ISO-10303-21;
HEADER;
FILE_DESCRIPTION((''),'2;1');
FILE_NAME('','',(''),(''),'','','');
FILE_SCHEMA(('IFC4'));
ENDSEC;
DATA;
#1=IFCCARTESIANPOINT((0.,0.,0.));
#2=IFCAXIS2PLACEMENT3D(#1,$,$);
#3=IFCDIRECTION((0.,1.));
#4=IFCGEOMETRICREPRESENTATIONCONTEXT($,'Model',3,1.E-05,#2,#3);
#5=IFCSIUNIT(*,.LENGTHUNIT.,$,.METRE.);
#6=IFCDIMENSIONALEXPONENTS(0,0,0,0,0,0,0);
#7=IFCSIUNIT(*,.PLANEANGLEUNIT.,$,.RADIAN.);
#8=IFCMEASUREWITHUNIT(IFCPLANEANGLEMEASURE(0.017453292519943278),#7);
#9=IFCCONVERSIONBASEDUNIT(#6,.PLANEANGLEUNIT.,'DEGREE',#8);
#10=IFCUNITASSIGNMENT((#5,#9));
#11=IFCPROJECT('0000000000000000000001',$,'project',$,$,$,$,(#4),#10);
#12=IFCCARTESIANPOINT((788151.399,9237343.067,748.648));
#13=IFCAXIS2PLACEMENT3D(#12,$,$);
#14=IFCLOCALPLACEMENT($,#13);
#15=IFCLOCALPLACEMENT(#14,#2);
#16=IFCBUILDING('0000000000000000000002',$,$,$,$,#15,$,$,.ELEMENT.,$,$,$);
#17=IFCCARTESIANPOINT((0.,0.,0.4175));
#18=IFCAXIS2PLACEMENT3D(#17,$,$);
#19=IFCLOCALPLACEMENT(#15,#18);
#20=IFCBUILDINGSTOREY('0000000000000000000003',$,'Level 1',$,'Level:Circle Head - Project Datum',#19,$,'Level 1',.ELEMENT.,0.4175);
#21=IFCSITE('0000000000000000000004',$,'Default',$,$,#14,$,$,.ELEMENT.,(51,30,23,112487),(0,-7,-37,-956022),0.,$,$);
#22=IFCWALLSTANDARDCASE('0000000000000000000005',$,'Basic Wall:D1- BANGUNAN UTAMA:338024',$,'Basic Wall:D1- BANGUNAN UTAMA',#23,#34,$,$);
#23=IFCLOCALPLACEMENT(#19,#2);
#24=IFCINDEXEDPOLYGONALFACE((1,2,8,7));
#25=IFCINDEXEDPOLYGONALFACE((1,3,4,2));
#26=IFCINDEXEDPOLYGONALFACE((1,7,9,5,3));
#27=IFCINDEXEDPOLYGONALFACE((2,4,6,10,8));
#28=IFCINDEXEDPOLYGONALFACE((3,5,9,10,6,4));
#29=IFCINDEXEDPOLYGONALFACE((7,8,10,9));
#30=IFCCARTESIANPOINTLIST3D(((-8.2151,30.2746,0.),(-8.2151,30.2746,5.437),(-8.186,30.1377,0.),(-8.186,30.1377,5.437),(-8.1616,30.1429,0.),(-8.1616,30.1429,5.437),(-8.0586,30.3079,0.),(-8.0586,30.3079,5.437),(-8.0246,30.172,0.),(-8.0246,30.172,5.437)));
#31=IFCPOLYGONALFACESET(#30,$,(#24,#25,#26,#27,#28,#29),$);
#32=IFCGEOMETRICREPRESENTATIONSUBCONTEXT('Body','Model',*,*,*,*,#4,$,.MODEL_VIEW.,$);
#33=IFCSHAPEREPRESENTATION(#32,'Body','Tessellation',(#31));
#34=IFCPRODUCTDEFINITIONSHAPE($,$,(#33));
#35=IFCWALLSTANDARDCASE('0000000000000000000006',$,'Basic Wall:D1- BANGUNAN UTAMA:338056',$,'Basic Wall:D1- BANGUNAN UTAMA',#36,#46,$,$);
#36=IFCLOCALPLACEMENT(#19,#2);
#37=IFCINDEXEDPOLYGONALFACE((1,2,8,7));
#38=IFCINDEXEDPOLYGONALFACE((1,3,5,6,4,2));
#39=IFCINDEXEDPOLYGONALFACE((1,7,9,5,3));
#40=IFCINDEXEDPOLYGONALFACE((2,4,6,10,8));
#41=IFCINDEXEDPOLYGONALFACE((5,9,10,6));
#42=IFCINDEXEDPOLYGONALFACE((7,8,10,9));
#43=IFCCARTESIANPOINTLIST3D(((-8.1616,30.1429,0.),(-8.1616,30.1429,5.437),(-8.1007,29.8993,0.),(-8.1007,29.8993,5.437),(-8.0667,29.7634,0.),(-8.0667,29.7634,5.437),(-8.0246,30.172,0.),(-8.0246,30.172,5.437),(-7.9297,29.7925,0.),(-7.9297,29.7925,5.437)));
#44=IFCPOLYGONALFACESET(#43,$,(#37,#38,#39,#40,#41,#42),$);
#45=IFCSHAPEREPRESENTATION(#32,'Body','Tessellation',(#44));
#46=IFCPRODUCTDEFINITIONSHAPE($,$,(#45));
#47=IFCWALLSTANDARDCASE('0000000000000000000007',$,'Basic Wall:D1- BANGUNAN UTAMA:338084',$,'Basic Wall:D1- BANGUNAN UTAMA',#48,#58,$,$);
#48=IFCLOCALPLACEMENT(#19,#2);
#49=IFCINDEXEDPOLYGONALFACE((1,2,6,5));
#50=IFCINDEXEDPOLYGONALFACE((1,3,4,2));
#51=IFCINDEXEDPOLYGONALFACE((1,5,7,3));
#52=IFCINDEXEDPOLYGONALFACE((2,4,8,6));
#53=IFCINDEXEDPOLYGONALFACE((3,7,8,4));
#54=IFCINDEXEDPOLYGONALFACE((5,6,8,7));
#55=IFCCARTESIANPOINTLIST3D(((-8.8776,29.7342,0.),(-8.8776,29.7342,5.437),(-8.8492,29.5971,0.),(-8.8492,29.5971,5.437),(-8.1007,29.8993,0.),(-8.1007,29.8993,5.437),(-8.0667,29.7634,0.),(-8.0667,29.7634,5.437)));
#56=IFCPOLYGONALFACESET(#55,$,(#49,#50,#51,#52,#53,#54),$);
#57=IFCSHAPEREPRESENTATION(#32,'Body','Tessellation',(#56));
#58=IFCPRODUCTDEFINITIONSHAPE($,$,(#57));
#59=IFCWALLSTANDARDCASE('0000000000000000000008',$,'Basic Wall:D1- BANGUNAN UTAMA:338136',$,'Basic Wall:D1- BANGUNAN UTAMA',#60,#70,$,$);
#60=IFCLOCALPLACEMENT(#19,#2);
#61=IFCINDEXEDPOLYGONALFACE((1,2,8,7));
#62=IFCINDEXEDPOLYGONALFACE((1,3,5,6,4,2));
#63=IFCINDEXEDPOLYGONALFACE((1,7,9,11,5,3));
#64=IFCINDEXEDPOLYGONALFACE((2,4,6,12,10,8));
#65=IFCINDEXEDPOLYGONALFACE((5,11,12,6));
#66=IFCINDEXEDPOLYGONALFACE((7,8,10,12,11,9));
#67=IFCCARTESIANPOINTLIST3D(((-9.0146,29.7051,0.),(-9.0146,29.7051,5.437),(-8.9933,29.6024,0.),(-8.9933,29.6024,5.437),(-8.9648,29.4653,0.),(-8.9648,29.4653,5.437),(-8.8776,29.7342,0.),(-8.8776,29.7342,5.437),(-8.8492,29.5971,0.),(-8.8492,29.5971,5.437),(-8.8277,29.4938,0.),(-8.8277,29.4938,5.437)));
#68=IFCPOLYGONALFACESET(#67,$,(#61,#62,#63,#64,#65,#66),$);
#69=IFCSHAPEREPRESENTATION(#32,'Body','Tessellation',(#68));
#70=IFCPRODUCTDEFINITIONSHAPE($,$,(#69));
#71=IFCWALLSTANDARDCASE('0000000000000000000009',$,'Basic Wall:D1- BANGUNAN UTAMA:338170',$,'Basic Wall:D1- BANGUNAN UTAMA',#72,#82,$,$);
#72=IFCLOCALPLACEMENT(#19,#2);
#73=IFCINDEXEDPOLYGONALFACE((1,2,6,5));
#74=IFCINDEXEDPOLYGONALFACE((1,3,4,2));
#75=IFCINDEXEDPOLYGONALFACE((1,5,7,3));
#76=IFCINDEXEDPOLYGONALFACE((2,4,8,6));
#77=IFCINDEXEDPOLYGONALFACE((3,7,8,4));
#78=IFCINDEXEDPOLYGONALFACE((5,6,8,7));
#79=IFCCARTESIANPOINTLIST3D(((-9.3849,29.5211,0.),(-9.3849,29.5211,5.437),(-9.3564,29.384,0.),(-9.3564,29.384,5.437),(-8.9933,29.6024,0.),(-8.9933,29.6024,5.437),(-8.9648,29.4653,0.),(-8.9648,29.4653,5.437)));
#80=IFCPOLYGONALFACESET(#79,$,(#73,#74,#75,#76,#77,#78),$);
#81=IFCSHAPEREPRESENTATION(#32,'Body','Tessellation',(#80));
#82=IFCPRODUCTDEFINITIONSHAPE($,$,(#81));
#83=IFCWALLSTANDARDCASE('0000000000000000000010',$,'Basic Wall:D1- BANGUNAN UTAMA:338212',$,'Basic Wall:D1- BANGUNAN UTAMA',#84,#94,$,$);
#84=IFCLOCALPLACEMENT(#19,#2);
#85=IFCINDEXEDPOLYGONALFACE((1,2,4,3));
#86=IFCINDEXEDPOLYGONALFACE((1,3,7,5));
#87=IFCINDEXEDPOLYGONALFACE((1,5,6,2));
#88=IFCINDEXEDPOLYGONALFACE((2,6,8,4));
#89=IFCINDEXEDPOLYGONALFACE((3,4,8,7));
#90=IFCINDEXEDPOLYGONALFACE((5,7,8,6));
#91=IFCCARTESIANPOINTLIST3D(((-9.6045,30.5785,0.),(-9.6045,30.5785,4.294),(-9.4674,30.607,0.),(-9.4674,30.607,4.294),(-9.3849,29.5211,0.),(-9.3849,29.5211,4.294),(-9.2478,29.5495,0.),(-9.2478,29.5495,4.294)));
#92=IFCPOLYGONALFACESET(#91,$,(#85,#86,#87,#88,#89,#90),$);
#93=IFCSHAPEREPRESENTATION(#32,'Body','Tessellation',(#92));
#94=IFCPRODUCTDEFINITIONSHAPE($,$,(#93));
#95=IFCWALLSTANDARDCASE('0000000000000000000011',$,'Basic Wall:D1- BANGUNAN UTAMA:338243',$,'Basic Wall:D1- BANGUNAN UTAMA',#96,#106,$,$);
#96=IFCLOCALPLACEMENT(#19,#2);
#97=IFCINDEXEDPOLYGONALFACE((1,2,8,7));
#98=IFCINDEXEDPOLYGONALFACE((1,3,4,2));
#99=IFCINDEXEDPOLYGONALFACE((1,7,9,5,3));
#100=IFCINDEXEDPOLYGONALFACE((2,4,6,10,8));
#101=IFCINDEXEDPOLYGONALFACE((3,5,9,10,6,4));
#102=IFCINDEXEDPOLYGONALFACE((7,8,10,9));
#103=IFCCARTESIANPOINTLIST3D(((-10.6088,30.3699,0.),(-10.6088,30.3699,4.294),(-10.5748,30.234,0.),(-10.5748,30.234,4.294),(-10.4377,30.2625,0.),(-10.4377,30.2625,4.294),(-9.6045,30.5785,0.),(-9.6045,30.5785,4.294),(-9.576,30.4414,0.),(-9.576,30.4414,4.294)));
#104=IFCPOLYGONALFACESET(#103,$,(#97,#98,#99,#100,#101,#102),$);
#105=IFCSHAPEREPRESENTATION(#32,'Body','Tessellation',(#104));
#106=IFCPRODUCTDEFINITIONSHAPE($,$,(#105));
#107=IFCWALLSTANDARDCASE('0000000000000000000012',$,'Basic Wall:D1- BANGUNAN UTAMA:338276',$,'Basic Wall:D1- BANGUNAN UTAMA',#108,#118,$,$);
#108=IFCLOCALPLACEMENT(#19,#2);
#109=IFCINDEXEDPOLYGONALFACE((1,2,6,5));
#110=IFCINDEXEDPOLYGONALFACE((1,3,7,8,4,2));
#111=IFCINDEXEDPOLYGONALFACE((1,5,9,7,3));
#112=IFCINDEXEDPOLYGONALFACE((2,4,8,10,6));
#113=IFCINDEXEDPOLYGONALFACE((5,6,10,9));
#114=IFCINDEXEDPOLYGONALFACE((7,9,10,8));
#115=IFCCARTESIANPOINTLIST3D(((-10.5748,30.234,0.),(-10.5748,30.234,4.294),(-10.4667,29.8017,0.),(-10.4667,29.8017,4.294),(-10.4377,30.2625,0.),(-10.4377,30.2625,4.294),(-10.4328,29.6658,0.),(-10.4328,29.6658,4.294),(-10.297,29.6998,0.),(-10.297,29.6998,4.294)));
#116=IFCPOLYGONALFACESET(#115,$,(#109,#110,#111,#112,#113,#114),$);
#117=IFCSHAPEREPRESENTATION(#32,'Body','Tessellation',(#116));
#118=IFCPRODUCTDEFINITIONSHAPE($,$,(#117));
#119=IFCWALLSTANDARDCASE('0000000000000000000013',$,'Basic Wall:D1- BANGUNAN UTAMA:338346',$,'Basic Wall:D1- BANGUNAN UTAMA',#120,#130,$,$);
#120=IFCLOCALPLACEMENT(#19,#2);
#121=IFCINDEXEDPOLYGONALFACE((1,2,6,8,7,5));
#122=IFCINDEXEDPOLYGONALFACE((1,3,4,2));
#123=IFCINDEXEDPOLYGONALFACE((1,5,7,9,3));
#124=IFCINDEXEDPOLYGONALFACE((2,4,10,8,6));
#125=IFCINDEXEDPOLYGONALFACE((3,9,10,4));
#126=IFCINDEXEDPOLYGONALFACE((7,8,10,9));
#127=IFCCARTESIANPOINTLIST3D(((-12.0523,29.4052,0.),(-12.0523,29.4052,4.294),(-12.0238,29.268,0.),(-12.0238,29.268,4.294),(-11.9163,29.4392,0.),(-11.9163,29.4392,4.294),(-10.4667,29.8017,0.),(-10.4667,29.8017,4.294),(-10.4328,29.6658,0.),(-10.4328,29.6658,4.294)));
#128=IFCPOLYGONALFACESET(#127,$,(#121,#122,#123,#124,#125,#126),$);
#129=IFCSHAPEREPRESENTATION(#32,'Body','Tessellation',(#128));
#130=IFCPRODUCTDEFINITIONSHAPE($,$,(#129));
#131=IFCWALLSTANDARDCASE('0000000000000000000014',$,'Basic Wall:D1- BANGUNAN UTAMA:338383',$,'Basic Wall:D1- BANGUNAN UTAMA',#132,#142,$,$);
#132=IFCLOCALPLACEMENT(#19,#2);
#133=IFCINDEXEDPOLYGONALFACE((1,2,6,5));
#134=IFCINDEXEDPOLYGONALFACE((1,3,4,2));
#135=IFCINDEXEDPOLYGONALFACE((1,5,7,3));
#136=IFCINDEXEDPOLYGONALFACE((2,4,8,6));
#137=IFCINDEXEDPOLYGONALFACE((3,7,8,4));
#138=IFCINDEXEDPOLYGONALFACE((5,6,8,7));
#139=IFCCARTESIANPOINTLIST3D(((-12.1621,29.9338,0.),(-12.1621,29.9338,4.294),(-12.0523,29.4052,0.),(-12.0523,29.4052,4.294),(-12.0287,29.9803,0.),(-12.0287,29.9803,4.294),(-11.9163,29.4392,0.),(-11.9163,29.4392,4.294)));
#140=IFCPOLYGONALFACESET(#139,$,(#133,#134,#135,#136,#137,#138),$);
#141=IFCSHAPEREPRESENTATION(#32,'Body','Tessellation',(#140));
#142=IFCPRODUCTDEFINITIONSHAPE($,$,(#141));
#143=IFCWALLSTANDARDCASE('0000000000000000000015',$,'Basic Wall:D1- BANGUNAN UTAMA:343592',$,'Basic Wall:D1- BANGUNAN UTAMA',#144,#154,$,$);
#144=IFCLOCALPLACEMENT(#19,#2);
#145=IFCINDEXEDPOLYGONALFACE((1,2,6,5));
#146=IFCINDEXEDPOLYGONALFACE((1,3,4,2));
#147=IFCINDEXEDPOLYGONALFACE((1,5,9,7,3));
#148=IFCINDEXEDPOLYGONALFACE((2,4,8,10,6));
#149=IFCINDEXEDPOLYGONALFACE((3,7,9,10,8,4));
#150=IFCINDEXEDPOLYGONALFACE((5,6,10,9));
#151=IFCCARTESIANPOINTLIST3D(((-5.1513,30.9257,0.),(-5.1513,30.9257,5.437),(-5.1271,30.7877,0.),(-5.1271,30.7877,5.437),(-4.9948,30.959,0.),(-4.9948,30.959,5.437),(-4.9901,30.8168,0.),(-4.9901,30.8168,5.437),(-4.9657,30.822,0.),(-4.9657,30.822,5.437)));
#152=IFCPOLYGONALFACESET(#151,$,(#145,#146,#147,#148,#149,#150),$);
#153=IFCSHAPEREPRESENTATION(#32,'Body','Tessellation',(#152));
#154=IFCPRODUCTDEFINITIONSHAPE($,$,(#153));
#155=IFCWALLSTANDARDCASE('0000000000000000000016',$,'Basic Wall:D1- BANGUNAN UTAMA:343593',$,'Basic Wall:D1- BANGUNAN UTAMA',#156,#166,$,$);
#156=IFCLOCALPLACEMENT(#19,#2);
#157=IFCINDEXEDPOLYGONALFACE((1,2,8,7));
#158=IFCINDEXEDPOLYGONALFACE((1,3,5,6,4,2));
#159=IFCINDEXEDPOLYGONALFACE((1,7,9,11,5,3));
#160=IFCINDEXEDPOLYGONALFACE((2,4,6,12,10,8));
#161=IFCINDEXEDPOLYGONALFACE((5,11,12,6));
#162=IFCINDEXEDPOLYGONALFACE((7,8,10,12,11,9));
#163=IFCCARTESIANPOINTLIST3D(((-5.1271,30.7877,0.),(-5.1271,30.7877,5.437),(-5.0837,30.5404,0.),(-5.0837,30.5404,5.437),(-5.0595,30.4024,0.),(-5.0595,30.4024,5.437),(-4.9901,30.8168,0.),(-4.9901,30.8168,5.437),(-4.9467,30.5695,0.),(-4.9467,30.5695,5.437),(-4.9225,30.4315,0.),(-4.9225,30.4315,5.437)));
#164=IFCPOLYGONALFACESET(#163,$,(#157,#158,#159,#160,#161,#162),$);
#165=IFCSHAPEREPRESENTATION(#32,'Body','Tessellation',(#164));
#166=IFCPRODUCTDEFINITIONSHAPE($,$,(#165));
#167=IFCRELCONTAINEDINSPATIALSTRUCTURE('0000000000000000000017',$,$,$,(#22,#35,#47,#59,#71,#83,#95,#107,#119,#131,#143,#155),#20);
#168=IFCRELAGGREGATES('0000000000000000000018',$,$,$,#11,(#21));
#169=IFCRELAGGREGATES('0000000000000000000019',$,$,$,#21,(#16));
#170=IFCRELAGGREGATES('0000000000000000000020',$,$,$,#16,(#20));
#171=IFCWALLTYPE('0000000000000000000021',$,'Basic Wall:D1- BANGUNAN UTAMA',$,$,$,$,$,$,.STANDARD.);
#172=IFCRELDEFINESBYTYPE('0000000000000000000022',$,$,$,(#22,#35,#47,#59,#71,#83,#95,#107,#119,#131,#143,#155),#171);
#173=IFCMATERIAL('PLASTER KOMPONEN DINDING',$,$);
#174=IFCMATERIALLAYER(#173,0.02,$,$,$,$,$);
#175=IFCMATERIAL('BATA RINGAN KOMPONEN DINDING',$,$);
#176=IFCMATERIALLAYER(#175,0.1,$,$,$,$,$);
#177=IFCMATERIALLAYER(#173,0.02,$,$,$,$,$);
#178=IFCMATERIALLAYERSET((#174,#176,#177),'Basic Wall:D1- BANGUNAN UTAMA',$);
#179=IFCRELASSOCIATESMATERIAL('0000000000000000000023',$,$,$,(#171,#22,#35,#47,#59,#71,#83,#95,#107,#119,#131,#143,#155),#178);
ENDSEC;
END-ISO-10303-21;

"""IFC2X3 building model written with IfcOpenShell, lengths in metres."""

from ifc_helpers import new_model, entity, si_unit, converted_unit, direction, frame, frame_2d, origin, place, context, subcontext, project, spatial, polyline, rectangle, outline, extrude, material, layer, layer_set, layer_usage, type_object, element, save


model = new_model("IFC2X3")

# Units and contexts
model_context = context("Model", 3, precision=1e-05, world=origin(), true_north=direction((0.0, 1.0)))
body_context = subcontext(model_context, "Body", "Model", "MODEL_VIEW")
ifc_project = project(units=[si_unit("LENGTHUNIT", "METRE"), converted_unit("PLANEANGLEUNIT", "DEGREE", entity("IfcPlaneAngleMeasure", 0.017453292519943278), si_unit("PLANEANGLEUNIT", "RADIAN"), dimensions=[0, 0, 0, 0, 0, 0, 0])], contexts=[model_context])

# Site, building, storey
site_placement = place(None, frame((788151.399, 9237343.067, 748.648)))
site = spatial("IfcSite", under=ifc_project, at=site_placement, Name="Default", CompositionType="ELEMENT", RefLatitude=(51, 30, 23, 112487), RefLongitude=(0, -7, -37, -956022), RefElevation=0.0)
building_placement = place(site_placement, origin())
building = spatial("IfcBuilding", under=site, at=building_placement, CompositionType="ELEMENT")
storey_placement = place(building_placement, frame((0.0, 0.0, 0.4175)))
storey = spatial("IfcBuildingStorey", under=building, at=storey_placement, Name="Level 1", ObjectType="Level:Circle Head - Project Datum", LongName="Level 1", CompositionType="ELEMENT", Elevation=0.4175)

# Walls
ifc_material_1 = material(Name="PLASTER KOMPONEN DINDING")
ifc_layer_1 = layer(ifc_material_1, 0.02)
ifc_material_2 = material(Name="BATA RINGAN KOMPONEN DINDING")
ifc_layer_2 = layer(ifc_material_2, 0.1)
ifc_layer_3 = layer(ifc_material_1, 0.02)
ifc_layer_set_1 = layer_set([ifc_layer_1, ifc_layer_2, ifc_layer_3], Name="Basic Wall:D1- BANGUNAN UTAMA")
wall_type_1 = type_object("IfcWallType", Name="Basic Wall:D1- BANGUNAN UTAMA", PredefinedType="STANDARD", material=ifc_layer_set_1)
ifc_layer_usage_1 = layer_usage(ifc_layer_set_1, "AXIS2", "NEGATIVE", 0.07)
wall_1_placement = place(storey_placement, frame((-8.2005, 30.2062, 0.0), z_axis=(0.0, 0.0, 1.0), x_axis=(0.978158, 0.207863, 0.0)))
element("IfcWallStandardCase", 1, at=wall_1_placement, inside=storey, type_object=wall_type_1, material=ifc_layer_usage_1, Name="Basic Wall:D1- BANGUNAN UTAMA:338024", ObjectType="Basic Wall:D1- BANGUNAN UTAMA", context=body_context, shape_type="SweptSolid", body=[
    extrude(outline(polyline([(0.165, -0.07), (0.16, 0.07), (0.0, 0.07), (0.0, -0.07), (0.0249, -0.07), (0.165, -0.07)])), origin(), (0.0, 0.0, 1.0), 5.437),
])
ifc_layer_usage_2 = layer_usage(ifc_layer_set_1, "AXIS2", "NEGATIVE", 0.07)
wall_2_placement = place(storey_placement, frame((-8.0937, 30.1598, 0.0), z_axis=(0.0, 0.0, 1.0), x_axis=(0.242594, -0.970128, 0.0)))
element("IfcWallStandardCase", 2, at=wall_2_placement, inside=storey, type_object=wall_type_1, material=ifc_layer_usage_2, Name="Basic Wall:D1- BANGUNAN UTAMA:338056", ObjectType="Basic Wall:D1- BANGUNAN UTAMA", context=body_context, shape_type="SweptSolid", body=[
    extrude(outline(polyline([(0.3912, -0.07), (0.3962, 0.07), (0.005, 0.07), (0.0, -0.07), (0.2511, -0.07), (0.3912, -0.07)])), origin(), (0.0, 0.0, 1.0), 5.437),
])
ifc_layer_usage_3 = layer_usage(ifc_layer_set_1, "AXIS2", "NEGATIVE", 0.07)
wall_3_placement = place(storey_placement, frame((-8.0813, 29.8318, 0.0), z_axis=(0.0, 0.0, 1.0), x_axis=(-0.978158, -0.207863, 0.0)))
element("IfcWallStandardCase", 3, at=wall_3_placement, inside=storey, type_object=wall_type_1, material=ifc_layer_usage_3, Name="Basic Wall:D1- BANGUNAN UTAMA:338084", ObjectType="Basic Wall:D1- BANGUNAN UTAMA", context=body_context, shape_type="SweptSolid", body=[
    extrude(outline(polyline([(0.7993, -0.07), (0.7999, 0.07), (0.0, 0.07), (0.005, -0.07), (0.7993, -0.07)])), origin(), (0.0, 0.0, 1.0), 5.437),
])
ifc_layer_usage_4 = layer_usage(ifc_layer_set_1, "AXIS2", "NEGATIVE", 0.07)
wall_4_placement = place(storey_placement, frame((-8.9462, 29.7199, 0.0), z_axis=(0.0, 0.0, 1.0), x_axis=(0.203342, -0.979108, 0.0)))
element("IfcWallStandardCase", 4, at=wall_4_placement, inside=storey, type_object=wall_type_1, material=ifc_layer_usage_4, Name="Basic Wall:D1- BANGUNAN UTAMA:338136", ObjectType="Basic Wall:D1- BANGUNAN UTAMA", context=body_context, shape_type="SweptSolid", body=[
    extrude(outline(polyline([(0.2455, -0.07), (0.2455, 0.07), (0.14, 0.07), (0.0, 0.07), (0.0006, -0.07), (0.1055, -0.07), (0.2455, -0.07)])), origin(), (0.0, 0.0, 1.0), 5.437),
])
ifc_layer_usage_5 = layer_usage(ifc_layer_set_1, "AXIS2", "NEGATIVE", 0.07)
wall_5_placement = place(storey_placement, frame((-8.979, 29.5339, 0.0), z_axis=(0.0, 0.0, 1.0), x_axis=(-0.979108, -0.203342, 0.0)))
element("IfcWallStandardCase", 5, at=wall_5_placement, inside=storey, type_object=wall_type_1, material=ifc_layer_usage_5, Name="Basic Wall:D1- BANGUNAN UTAMA:338170", ObjectType="Basic Wall:D1- BANGUNAN UTAMA", context=body_context, shape_type="SweptSolid", body=[
    extrude(rectangle(XDim=0.4, YDim=0.14, at=frame_2d((0.2, 0.0), x_axis=(-1.0, 0.0))), origin(), (0.0, 0.0, 1.0), 5.437),
])
ifc_layer_usage_6 = layer_usage(ifc_layer_set_1, "AXIS2", "NEGATIVE", 0.07)
wall_6_placement = place(storey_placement, frame((-9.3164, 29.5353, 0.0), z_axis=(0.0, 0.0, 1.0), x_axis=(-0.203342, 0.979108, 0.0)))
element("IfcWallStandardCase", 6, at=wall_6_placement, inside=storey, type_object=wall_type_1, material=ifc_layer_usage_6, Name="Basic Wall:D1- BANGUNAN UTAMA:338212", ObjectType="Basic Wall:D1- BANGUNAN UTAMA", context=body_context, shape_type="SweptSolid", body=[
    extrude(rectangle(XDim=1.08, YDim=0.14, at=frame_2d((0.54, 0.0), x_axis=(-1.0, 0.0))), origin(), (0.0, 0.0, 1.0), 4.294),
])
ifc_layer_usage_7 = layer_usage(ifc_layer_set_1, "AXIS2", "NEGATIVE", 0.07)
wall_7_placement = place(storey_placement, frame((-9.5903, 30.51, 0.0), z_axis=(0.0, 0.0, 1.0), x_axis=(-0.979108, -0.203342, 0.0)))
element("IfcWallStandardCase", 7, at=wall_7_placement, inside=storey, type_object=wall_type_1, material=ifc_layer_usage_7, Name="Basic Wall:D1- BANGUNAN UTAMA:338243", ObjectType="Basic Wall:D1- BANGUNAN UTAMA", context=body_context, shape_type="SweptSolid", body=[
    extrude(outline(polyline([(1.0258, -0.07), (1.0201, 0.07), (0.88, 0.07), (0.0, 0.07), (0.0, -0.07), (1.0258, -0.07)])), origin(), (0.0, 0.0, 1.0), 4.294),
])
ifc_layer_usage_8 = layer_usage(ifc_layer_set_1, "AXIS2", "NEGATIVE", 0.07)
wall_8_placement = place(storey_placement, frame((-10.5069, 30.251, 0.0), z_axis=(0.0, 0.0, 1.0), x_axis=(0.242594, -0.970128, 0.0)))
element("IfcWallStandardCase", 8, at=wall_8_placement, inside=storey, type_object=wall_type_1, material=ifc_layer_usage_8, Name="Basic Wall:D1- BANGUNAN UTAMA:338276", ObjectType="Basic Wall:D1- BANGUNAN UTAMA", context=body_context, shape_type="SweptSolid", body=[
    extrude(outline(polyline([(0.5856, -0.07), (0.5856, 0.07), (0.0056, 0.07), (0.0, -0.07), (0.4456, -0.07), (0.5856, -0.07)])), origin(), (0.0, 0.0, 1.0), 4.294),
])
ifc_layer_usage_9 = layer_usage(ifc_layer_set_1, "AXIS2", "NEGATIVE", 0.07)
wall_9_placement = place(storey_placement, frame((-10.4498, 29.7337, 0.0), z_axis=(0.0, 0.0, 1.0), x_axis=(-0.970128, -0.242594, 0.0)))
element("IfcWallStandardCase", 9, at=wall_9_placement, inside=storey, type_object=wall_type_1, material=ifc_layer_usage_9, Name="Basic Wall:D1- BANGUNAN UTAMA:338346", ObjectType="Basic Wall:D1- BANGUNAN UTAMA", context=body_context, shape_type="SweptSolid", body=[
    extrude(outline(polyline([(1.6344, -0.07), (1.64, 0.07), (0.0, 0.07), (0.0, -0.07), (1.4942, -0.07), (1.6344, -0.07)])), origin(), (0.0, 0.0, 1.0), 4.294),
])
ifc_layer_usage_10 = layer_usage(ifc_layer_set_1, "AXIS2", "NEGATIVE", 0.07)
wall_10_placement = place(storey_placement, frame((-11.9837, 29.4194, 0.0), z_axis=(0.0, 0.0, 1.0), x_axis=(-0.203342, 0.979108, 0.0)))
element("IfcWallStandardCase", 10, at=wall_10_placement, inside=storey, type_object=wall_type_1, material=ifc_layer_usage_10, Name="Basic Wall:D1- BANGUNAN UTAMA:338383", ObjectType="Basic Wall:D1- BANGUNAN UTAMA", context=body_context, shape_type="SweptSolid", body=[
    extrude(outline(polyline([(0.5583, -0.07), (0.5399, 0.07), (0.0, 0.07), (0.0056, -0.07), (0.5583, -0.07)])), origin(), (0.0, 0.0, 1.0), 4.294),
])
ifc_layer_usage_11 = layer_usage(ifc_layer_set_1, "AXIS2", "POSITIVE", -0.07)
wall_11_placement = place(storey_placement, frame((-4.9803, 30.8905, 0.0), z_axis=(0.0, 0.0, 1.0), x_axis=(-0.978158, -0.207863, 0.0)))
element("IfcWallStandardCase", 11, at=wall_11_placement, inside=storey, type_object=wall_type_1, material=ifc_layer_usage_11, Name="Basic Wall:D1- BANGUNAN UTAMA:343592", ObjectType="Basic Wall:D1- BANGUNAN UTAMA", context=body_context, shape_type="SweptSolid", body=[
    extrude(outline(polyline([(0.16, -0.07), (0.165, 0.07), (0.0249, 0.07), (0.0, 0.07), (0.0, -0.07), (0.16, -0.07)])), origin(), (0.0, 0.0, 1.0), 5.437),
])
ifc_layer_usage_12 = layer_usage(ifc_layer_set_1, "AXIS2", "POSITIVE", -0.07)
wall_12_placement = place(storey_placement, frame((-5.059, 30.8047, 0.0), z_axis=(0.0, 0.0, 1.0), x_axis=(0.172867, -0.984945, 0.0)))
element("IfcWallStandardCase", 12, at=wall_12_placement, inside=storey, type_object=wall_type_1, material=ifc_layer_usage_12, Name="Basic Wall:D1- BANGUNAN UTAMA:343593", ObjectType="Basic Wall:D1- BANGUNAN UTAMA", context=body_context, shape_type="SweptSolid", body=[
    extrude(outline(polyline([(0.3962, -0.07), (0.3912, 0.07), (0.2511, 0.07), (0.0, 0.07), (0.005, -0.07), (0.2561, -0.07), (0.3962, -0.07)])), origin(), (0.0, 0.0, 1.0), 5.437),
])

save(model, "model.ifc")
